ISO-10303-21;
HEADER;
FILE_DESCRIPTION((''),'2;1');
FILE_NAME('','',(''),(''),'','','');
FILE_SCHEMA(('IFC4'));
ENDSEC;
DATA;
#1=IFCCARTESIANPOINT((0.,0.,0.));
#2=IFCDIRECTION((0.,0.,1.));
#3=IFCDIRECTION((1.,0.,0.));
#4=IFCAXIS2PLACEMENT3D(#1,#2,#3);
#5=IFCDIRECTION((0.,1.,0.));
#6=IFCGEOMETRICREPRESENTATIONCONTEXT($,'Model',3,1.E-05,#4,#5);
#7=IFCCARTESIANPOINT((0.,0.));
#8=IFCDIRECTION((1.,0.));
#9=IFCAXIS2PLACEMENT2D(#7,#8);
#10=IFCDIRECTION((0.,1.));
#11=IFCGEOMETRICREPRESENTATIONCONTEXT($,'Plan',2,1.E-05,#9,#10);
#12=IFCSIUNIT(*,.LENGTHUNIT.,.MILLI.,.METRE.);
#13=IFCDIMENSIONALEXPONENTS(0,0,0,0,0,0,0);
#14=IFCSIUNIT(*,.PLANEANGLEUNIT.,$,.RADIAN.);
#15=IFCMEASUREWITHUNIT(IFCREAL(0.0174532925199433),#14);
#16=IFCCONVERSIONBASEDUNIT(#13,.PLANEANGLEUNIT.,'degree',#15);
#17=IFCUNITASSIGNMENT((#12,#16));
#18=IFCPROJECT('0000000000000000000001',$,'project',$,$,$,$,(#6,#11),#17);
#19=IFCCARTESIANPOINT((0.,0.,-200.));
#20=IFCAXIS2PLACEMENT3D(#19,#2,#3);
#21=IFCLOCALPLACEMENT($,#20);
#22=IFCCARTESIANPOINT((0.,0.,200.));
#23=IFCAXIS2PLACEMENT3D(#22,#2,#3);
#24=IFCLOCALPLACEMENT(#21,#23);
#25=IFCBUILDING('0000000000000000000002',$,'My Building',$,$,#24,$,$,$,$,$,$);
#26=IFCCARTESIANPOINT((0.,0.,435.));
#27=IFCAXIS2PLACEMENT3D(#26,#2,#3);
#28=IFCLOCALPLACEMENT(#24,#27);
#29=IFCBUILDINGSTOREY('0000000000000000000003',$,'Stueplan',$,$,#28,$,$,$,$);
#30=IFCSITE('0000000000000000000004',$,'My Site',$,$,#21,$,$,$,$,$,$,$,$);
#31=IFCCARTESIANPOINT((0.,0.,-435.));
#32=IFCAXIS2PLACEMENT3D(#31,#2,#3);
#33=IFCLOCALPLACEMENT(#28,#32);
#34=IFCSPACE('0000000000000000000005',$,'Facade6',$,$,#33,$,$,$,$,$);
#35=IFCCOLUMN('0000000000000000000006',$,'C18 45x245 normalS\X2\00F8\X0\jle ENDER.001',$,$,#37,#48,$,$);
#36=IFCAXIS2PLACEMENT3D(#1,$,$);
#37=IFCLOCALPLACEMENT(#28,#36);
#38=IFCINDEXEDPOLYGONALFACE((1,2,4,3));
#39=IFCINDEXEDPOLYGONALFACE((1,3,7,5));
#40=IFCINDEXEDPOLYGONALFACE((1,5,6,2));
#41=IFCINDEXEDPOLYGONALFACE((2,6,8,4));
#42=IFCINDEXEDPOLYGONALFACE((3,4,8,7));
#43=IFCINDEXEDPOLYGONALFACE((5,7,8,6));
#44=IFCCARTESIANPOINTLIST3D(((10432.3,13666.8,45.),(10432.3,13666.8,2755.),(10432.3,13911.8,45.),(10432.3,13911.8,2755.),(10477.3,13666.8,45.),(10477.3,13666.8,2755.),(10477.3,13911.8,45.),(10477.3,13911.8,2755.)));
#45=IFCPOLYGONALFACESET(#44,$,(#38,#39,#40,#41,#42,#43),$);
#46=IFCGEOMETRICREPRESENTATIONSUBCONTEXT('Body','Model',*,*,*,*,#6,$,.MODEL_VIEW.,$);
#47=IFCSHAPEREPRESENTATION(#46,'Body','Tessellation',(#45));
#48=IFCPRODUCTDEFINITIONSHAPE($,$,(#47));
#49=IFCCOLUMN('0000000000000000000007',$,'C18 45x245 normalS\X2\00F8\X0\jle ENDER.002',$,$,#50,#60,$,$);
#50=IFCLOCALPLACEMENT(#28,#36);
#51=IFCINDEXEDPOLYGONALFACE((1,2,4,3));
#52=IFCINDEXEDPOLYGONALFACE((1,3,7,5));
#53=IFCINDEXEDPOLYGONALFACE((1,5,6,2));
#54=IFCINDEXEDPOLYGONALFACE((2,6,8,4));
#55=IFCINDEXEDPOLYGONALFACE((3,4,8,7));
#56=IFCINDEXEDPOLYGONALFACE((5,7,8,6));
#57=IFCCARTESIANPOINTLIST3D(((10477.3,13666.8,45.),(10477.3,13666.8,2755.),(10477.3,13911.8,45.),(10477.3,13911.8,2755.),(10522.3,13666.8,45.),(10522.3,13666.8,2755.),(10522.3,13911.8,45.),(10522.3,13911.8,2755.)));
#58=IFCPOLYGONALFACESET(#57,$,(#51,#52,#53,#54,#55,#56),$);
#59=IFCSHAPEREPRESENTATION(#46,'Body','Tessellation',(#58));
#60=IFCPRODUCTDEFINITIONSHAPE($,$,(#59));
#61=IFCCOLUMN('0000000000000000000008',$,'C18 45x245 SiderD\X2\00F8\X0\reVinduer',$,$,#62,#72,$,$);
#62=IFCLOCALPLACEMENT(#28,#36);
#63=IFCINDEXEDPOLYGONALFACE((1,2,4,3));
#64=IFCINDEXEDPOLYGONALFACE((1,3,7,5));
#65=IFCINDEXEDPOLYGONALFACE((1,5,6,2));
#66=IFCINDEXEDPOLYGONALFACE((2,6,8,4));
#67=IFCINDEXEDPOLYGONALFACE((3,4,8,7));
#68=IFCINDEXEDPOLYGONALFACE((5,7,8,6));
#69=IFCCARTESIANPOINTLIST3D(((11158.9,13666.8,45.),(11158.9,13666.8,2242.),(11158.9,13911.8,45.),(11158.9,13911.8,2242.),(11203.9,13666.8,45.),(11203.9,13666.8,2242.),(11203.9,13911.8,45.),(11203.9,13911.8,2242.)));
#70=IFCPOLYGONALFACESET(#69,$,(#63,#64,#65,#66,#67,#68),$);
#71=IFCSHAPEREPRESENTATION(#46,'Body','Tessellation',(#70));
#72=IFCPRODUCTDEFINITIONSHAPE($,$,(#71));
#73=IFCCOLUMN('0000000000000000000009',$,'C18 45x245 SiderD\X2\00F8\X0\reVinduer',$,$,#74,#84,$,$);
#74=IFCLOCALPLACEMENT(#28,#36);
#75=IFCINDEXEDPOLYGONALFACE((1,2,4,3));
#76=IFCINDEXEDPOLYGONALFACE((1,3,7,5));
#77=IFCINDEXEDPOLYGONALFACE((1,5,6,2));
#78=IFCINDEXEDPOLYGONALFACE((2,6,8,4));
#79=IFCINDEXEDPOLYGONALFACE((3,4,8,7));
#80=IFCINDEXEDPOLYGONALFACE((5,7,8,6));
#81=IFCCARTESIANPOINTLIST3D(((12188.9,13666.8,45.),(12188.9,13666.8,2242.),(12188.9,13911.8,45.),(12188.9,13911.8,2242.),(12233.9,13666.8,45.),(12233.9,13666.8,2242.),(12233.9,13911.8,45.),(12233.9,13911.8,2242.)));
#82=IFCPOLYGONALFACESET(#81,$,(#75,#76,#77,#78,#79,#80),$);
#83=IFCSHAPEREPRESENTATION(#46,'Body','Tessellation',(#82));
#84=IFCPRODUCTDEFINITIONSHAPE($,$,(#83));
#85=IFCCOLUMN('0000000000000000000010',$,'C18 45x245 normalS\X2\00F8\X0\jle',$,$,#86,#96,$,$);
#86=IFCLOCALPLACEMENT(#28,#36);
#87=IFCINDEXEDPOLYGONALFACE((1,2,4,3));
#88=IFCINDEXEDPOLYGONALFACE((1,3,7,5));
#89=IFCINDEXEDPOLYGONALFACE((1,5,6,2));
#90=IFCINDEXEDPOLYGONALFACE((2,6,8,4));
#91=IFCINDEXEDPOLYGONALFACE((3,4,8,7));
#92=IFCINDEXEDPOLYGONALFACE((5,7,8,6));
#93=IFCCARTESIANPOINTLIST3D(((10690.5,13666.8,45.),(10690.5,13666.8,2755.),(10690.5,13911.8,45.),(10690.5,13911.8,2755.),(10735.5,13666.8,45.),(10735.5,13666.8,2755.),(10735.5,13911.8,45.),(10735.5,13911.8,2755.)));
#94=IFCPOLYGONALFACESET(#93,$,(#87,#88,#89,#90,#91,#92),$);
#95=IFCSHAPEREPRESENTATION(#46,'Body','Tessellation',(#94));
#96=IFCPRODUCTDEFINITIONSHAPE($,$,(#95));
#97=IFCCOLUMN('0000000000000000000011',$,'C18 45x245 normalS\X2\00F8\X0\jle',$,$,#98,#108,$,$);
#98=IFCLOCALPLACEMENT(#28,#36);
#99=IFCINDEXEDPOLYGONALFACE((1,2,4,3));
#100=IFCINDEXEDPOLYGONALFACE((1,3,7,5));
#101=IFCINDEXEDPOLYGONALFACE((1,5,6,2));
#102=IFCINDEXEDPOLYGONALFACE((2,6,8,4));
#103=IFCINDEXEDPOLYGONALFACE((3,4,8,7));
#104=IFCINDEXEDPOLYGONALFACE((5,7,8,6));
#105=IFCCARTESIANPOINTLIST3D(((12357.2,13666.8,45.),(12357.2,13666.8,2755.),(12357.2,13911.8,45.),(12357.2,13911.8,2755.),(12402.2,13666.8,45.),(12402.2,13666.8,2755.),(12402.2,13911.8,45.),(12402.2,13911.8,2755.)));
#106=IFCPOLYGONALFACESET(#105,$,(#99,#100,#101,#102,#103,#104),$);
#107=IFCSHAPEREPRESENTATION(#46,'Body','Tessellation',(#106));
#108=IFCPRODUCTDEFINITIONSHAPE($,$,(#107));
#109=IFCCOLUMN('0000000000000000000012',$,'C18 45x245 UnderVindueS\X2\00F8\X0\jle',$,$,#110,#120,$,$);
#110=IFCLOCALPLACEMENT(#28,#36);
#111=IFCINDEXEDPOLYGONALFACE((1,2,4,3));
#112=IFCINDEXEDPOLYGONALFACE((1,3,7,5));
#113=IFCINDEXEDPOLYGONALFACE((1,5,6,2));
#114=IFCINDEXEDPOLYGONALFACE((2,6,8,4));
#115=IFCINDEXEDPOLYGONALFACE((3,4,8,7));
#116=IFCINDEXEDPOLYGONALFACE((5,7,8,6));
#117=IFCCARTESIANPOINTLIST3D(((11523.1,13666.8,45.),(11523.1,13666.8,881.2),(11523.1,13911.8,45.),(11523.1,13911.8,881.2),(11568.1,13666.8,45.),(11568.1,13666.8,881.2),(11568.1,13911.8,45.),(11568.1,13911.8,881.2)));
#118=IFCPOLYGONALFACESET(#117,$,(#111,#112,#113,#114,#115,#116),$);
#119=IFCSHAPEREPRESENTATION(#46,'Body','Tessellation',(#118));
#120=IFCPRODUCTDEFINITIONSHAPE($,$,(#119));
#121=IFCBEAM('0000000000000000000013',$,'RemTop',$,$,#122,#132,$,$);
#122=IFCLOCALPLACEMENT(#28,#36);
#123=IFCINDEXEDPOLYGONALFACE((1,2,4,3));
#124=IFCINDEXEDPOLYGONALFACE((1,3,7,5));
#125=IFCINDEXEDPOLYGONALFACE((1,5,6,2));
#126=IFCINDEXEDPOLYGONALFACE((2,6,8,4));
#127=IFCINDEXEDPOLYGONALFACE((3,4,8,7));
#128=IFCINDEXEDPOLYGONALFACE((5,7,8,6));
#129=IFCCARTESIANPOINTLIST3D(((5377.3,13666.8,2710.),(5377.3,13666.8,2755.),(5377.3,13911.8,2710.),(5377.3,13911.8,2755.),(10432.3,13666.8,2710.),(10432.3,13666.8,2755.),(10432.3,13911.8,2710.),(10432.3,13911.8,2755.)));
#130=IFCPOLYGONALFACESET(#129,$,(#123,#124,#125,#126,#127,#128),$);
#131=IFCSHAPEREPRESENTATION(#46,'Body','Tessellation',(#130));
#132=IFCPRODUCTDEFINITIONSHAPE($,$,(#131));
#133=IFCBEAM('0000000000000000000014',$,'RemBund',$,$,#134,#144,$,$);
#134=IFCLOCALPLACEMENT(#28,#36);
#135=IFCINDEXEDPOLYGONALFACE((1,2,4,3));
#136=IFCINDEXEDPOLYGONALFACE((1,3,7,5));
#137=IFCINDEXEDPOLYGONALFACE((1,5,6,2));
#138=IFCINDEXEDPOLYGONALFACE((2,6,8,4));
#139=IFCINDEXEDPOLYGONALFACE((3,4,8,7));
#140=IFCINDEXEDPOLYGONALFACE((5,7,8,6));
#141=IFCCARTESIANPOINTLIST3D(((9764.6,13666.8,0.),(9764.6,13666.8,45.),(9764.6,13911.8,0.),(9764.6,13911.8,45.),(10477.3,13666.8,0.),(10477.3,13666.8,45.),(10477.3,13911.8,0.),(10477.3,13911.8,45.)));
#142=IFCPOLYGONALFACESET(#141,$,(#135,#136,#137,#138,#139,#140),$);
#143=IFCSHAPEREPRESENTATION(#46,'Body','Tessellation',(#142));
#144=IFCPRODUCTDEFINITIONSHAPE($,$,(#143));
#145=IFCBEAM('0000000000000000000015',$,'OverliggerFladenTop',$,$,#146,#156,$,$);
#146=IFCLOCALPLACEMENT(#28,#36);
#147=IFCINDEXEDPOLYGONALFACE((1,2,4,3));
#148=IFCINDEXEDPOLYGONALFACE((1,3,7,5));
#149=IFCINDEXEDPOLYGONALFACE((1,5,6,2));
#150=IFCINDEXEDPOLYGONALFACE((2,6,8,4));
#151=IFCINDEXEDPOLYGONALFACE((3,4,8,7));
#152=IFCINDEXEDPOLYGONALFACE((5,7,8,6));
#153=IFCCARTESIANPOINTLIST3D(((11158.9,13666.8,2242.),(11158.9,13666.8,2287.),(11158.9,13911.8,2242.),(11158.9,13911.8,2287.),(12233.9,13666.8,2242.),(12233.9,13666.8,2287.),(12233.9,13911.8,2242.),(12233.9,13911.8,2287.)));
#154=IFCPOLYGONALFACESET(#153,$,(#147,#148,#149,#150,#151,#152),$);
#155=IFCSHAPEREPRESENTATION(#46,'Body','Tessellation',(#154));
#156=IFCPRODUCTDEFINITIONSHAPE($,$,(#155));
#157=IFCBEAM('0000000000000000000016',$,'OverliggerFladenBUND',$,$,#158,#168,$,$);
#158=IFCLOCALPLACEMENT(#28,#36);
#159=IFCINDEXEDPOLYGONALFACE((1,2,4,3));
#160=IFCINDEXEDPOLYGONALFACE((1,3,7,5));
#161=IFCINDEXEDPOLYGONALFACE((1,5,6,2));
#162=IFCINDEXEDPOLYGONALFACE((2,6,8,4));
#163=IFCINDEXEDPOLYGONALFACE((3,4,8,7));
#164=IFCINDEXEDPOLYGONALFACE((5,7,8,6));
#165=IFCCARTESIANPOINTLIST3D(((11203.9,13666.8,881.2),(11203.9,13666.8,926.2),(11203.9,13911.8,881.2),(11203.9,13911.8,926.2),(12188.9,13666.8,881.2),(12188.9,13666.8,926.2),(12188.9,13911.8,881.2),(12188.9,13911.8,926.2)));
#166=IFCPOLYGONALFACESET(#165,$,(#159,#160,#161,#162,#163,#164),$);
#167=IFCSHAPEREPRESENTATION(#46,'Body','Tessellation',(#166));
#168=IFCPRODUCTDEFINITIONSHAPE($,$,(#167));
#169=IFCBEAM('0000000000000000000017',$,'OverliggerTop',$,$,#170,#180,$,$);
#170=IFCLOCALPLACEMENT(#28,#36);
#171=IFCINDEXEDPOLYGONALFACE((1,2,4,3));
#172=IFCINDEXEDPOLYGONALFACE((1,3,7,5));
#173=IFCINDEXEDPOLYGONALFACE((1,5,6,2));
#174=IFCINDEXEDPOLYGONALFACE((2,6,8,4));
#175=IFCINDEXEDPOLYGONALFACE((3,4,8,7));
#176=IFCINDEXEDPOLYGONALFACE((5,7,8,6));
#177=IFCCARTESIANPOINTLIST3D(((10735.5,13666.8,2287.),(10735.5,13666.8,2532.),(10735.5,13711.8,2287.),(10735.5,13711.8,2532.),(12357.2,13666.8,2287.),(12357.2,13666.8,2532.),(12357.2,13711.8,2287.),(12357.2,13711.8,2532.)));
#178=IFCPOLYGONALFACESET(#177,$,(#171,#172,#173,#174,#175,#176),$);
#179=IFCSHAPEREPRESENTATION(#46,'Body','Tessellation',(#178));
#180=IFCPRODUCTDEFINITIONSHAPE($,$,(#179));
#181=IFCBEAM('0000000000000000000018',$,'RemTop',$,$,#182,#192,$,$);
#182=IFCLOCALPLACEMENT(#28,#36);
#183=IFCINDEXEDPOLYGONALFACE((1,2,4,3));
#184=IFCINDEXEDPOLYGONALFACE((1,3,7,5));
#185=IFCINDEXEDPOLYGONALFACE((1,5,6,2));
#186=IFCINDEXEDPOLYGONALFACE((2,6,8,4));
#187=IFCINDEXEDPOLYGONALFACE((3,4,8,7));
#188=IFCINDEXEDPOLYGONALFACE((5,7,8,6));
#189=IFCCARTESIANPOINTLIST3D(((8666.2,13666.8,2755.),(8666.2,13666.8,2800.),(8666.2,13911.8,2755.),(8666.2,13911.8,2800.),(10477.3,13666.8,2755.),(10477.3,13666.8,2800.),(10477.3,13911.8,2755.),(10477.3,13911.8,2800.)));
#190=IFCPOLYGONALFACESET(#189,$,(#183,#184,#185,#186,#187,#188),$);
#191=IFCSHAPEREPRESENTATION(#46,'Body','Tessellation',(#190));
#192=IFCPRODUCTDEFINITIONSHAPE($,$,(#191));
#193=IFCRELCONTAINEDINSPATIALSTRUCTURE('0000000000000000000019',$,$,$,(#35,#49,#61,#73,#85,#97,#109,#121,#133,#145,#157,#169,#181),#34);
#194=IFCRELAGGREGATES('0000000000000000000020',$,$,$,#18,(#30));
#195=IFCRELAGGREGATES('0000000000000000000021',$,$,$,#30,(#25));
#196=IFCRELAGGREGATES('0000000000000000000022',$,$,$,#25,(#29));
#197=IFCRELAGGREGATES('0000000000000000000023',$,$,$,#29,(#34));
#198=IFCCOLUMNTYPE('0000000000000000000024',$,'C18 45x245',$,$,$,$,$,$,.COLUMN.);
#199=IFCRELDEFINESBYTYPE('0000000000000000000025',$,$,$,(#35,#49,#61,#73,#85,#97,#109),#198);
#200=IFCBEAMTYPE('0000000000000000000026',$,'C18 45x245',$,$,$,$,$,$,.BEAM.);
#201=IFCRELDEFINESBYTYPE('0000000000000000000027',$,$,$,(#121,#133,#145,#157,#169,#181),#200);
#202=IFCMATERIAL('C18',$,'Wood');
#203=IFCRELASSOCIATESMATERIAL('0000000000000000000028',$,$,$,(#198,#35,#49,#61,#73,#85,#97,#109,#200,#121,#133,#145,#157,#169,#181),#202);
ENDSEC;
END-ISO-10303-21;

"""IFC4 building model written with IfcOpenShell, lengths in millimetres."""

from ifc_helpers import new_model, entity, si_unit, converted_unit, direction, frame, origin_with_axes, origin_2d_with_axis, place, context, subcontext, project, spatial, rectangle, extrude, material, material_profile, profile_set, profile_usage, type_object, element, save


model = new_model("IFC4")

# Units and contexts
model_context = context("Model", 3, precision=1e-05, world=origin_with_axes(), true_north=direction((0.0, 1.0, 0.0)))
plan_context = context("Plan", 2, precision=1e-05, world=origin_2d_with_axis(), true_north=direction((0.0, 1.0)))
body_context_1 = subcontext(model_context, "Body", "Model", "MODEL_VIEW")
ifc_project = project(units=[si_unit("LENGTHUNIT", "METRE", prefix="MILLI"), converted_unit("PLANEANGLEUNIT", "degree", entity("IfcReal", 0.0174532925199433), si_unit("PLANEANGLEUNIT", "RADIAN"), dimensions=[0, 0, 0, 0, 0, 0, 0])], contexts=[model_context, plan_context])

# Site, building, storey, space
site_placement = place(None, frame((0.0, 0.0, -200.0), z_axis=(0.0, 0.0, 1.0), x_axis=(1.0, 0.0, 0.0)))
site = spatial("IfcSite", under=ifc_project, at=site_placement, Name="My Site")
building_placement = place(site_placement, frame((0.0, 0.0, 200.0), z_axis=(0.0, 0.0, 1.0), x_axis=(1.0, 0.0, 0.0)))
building = spatial("IfcBuilding", under=site, at=building_placement, Name="My Building")
storey_placement = place(building_placement, frame((0.0, 0.0, 435.0), z_axis=(0.0, 0.0, 1.0), x_axis=(1.0, 0.0, 0.0)))
storey = spatial("IfcBuildingStorey", under=building, at=storey_placement, Name="Stueplan")
space_1_placement = place(storey_placement, frame((0.0, 0.0, -435.0), z_axis=(0.0, 0.0, 1.0), x_axis=(1.0, 0.0, 0.0)))
space_1 = spatial("IfcSpace", under=storey, at=space_1_placement, Name="Facade6")

# Columns
ifc_material = material(Name="C18", Category="Wood")
ifc_material_profile_1 = material_profile(ifc_material, rectangle(XDim=45.0, YDim=245.0))
ifc_profile_set_1 = profile_set([ifc_material_profile_1], Name="woodStructural")
ifc_profile_usage_1 = profile_usage(ifc_profile_set_1, cardinal=9)
column_type = type_object("IfcColumnType", Name="C18 45x245", PredefinedType="COLUMN", material=ifc_profile_set_1)
column_1_placement = place(space_1_placement, frame((10432.3, 13911.8, 480.0), z_axis=(0.0, 0.0, 1.0), x_axis=(1.0, 0.0, 0.0)))
element("IfcColumn", 1, at=column_1_placement, inside=space_1, type_object=column_type, material=ifc_profile_usage_1, Name="C18 45x245 normalSøjle ENDER.001", context=body_context_1, shape_type="SweptSolid", body=[
    extrude(rectangle(XDim=45.0, YDim=245.0), frame((22.5, -122.5, 0.0), z_axis=(0.0, 0.0, 1.0), x_axis=(1.0, 0.0, 0.0)), (0.0, 0.0, 1.0), 2710.0),
])
ifc_profile_usage_2 = profile_usage(ifc_profile_set_1, cardinal=9)
column_2_placement = place(space_1_placement, frame((10477.3, 13911.8, 480.0), z_axis=(0.0, 0.0, 1.0), x_axis=(1.0, 0.0, 0.0)))
element("IfcColumn", 2, at=column_2_placement, inside=space_1, type_object=column_type, material=ifc_profile_usage_2, Name="C18 45x245 normalSøjle ENDER.002", context=body_context_1, shape_type="SweptSolid", body=[
    extrude(rectangle(XDim=45.0, YDim=245.0), frame((22.5, -122.5, 0.0), z_axis=(0.0, 0.0, 1.0), x_axis=(1.0, 0.0, 0.0)), (0.0, 0.0, 1.0), 2710.0),
])
ifc_profile_usage_3 = profile_usage(ifc_profile_set_1, cardinal=9)
column_3_placement = place(space_1_placement, frame((11158.9, 13911.8, 480.0), z_axis=(0.0, 0.0, 1.0), x_axis=(1.0, 0.0, 0.0)))
element("IfcColumn", 3, at=column_3_placement, inside=space_1, type_object=column_type, material=ifc_profile_usage_3, Name="C18 45x245 SiderDøreVinduer", context=body_context_1, shape_type="SweptSolid", body=[
    extrude(rectangle(XDim=45.0, YDim=245.0), frame((22.5, -122.5, 0.0), z_axis=(0.0, 0.0, 1.0), x_axis=(1.0, 0.0, 0.0)), (0.0, 0.0, 1.0), 2197.0),
])
ifc_profile_usage_4 = profile_usage(ifc_profile_set_1, cardinal=9)
column_4_placement = place(space_1_placement, frame((12188.9, 13911.8, 480.0), z_axis=(0.0, 0.0, 1.0), x_axis=(1.0, 0.0, 0.0)))
element("IfcColumn", 4, at=column_4_placement, inside=space_1, type_object=column_type, material=ifc_profile_usage_4, Name="C18 45x245 SiderDøreVinduer", context=body_context_1, shape_type="SweptSolid", body=[
    extrude(rectangle(XDim=45.0, YDim=245.0), frame((22.5, -122.5, 0.0), z_axis=(0.0, 0.0, 1.0), x_axis=(1.0, 0.0, 0.0)), (0.0, 0.0, 1.0), 2197.0),
])
ifc_profile_usage_5 = profile_usage(ifc_profile_set_1, cardinal=9)
column_5_placement = place(space_1_placement, frame((10690.5, 13911.8, 480.0), z_axis=(0.0, 0.0, 1.0), x_axis=(1.0, 0.0, 0.0)))
element("IfcColumn", 5, at=column_5_placement, inside=space_1, type_object=column_type, material=ifc_profile_usage_5, Name="C18 45x245 normalSøjle", context=body_context_1, shape_type="SweptSolid", body=[
    extrude(rectangle(XDim=45.0, YDim=245.0), frame((22.5, -122.5, 0.0), z_axis=(0.0, 0.0, 1.0), x_axis=(1.0, 0.0, 0.0)), (0.0, 0.0, 1.0), 2710.0),
])
ifc_profile_usage_6 = profile_usage(ifc_profile_set_1, cardinal=9)
column_6_placement = place(space_1_placement, frame((12357.2, 13911.8, 480.0), z_axis=(0.0, 0.0, 1.0), x_axis=(1.0, 0.0, 0.0)))
element("IfcColumn", 6, at=column_6_placement, inside=space_1, type_object=column_type, material=ifc_profile_usage_6, Name="C18 45x245 normalSøjle", context=body_context_1, shape_type="SweptSolid", body=[
    extrude(rectangle(XDim=45.0, YDim=245.0), frame((22.5, -122.5, 0.0), z_axis=(0.0, 0.0, 1.0), x_axis=(1.0, 0.0, 0.0)), (0.0, 0.0, 1.0), 2710.0),
])
ifc_profile_usage_7 = profile_usage(ifc_profile_set_1, cardinal=9)
column_7_placement = place(space_1_placement, frame((11523.1, 13911.8, 480.0), z_axis=(0.0, 0.0, 1.0), x_axis=(1.0, 0.0, 0.0)))
element("IfcColumn", 7, at=column_7_placement, inside=space_1, type_object=column_type, material=ifc_profile_usage_7, Name="C18 45x245 UnderVindueSøjle", context=body_context_1, shape_type="SweptSolid", body=[
    extrude(rectangle(XDim=45.0, YDim=245.0), frame((22.5, -122.5, 0.0), z_axis=(0.0, 0.0, 1.0), x_axis=(1.0, 0.0, 0.0)), (0.0, 0.0, 1.0), 836.2),
])

# Beams
ifc_material_profile_2 = material_profile(ifc_material, rectangle(XDim=45.0, YDim=245.0), Name="concrete")
ifc_profile_set_2 = profile_set([ifc_material_profile_2], Name="woodStructural")
ifc_profile_usage_8 = profile_usage(ifc_profile_set_2)
beam_type_1 = type_object("IfcBeamType", Name="C18 45x245", PredefinedType="BEAM", material=ifc_profile_set_2)
beam_1_placement = place(space_1_placement, frame((10432.3, 13789.3, 3167.5), z_axis=(-1.0, 0.0, 0.0), x_axis=(0.0, 0.0, 1.0)))
element("IfcBeam", 8, at=beam_1_placement, inside=space_1, type_object=beam_type_1, material=ifc_profile_usage_8, Name="RemTop", context=body_context_1, shape_type="SweptSolid", body=[
    extrude(rectangle(XDim=45.0, YDim=245.0), origin_with_axes(), (0.0, 0.0, 1.0), 5055.0),
])
ifc_profile_usage_9 = profile_usage(ifc_profile_set_2)
beam_2_placement = place(space_1_placement, frame((10477.3, 13789.3, 457.5), z_axis=(-1.0, 0.0, 0.0), x_axis=(0.0, 0.0, 1.0)))
element("IfcBeam", 9, at=beam_2_placement, inside=space_1, type_object=beam_type_1, material=ifc_profile_usage_9, Name="RemBund", context=body_context_1, shape_type="SweptSolid", body=[
    extrude(rectangle(XDim=45.0, YDim=245.0), origin_with_axes(), (0.0, 0.0, 1.0), 712.7),
])
ifc_profile_usage_10 = profile_usage(ifc_profile_set_2)
beam_3_placement = place(space_1_placement, frame((12233.9, 13789.3, 2699.5), z_axis=(-1.0, 0.0, 0.0), x_axis=(0.0, 0.0, 1.0)))
element("IfcBeam", 10, at=beam_3_placement, inside=space_1, type_object=beam_type_1, material=ifc_profile_usage_10, Name="OverliggerFladenTop", context=body_context_1, shape_type="SweptSolid", body=[
    extrude(rectangle(XDim=45.0, YDim=245.0), origin_with_axes(), (0.0, 0.0, 1.0), 1075.0),
])
ifc_profile_usage_11 = profile_usage(ifc_profile_set_2)
beam_4_placement = place(space_1_placement, frame((12188.9, 13789.3, 1338.7), z_axis=(-1.0, 0.0, 0.0), x_axis=(0.0, 0.0, 1.0)))
element("IfcBeam", 11, at=beam_4_placement, inside=space_1, type_object=beam_type_1, material=ifc_profile_usage_11, Name="OverliggerFladenBUND", context=body_context_1, shape_type="SweptSolid", body=[
    extrude(rectangle(XDim=45.0, YDim=245.0), origin_with_axes(), (0.0, 0.0, 1.0), 985.0),
])
ifc_profile_usage_12 = profile_usage(ifc_profile_set_2)
beam_5_placement = place(space_1_placement, frame((10735.5, 13689.3, 2844.5), z_axis=(1.0, 0.0, 0.0), x_axis=(0.0, -1.0, 0.0)))
element("IfcBeam", 12, at=beam_5_placement, inside=space_1, type_object=beam_type_1, material=ifc_profile_usage_12, Name="OverliggerTop", context=body_context_1, shape_type="SweptSolid", body=[
    extrude(rectangle(XDim=45.0, YDim=245.0), origin_with_axes(), (0.0, 0.0, 1.0), 1621.7),
])
ifc_profile_usage_13 = profile_usage(ifc_profile_set_2)
beam_6_placement = place(space_1_placement, frame((10477.3, 13789.3, 3212.5), z_axis=(-1.0, 0.0, 0.0), x_axis=(0.0, 0.0, 1.0)))
element("IfcBeam", 13, at=beam_6_placement, inside=space_1, type_object=beam_type_1, material=ifc_profile_usage_13, Name="RemTop", context=body_context_1, shape_type="SweptSolid", body=[
    extrude(rectangle(XDim=45.0, YDim=245.0), origin_with_axes(), (0.0, 0.0, 1.0), 1811.1),
])

save(model, "model.ifc")
